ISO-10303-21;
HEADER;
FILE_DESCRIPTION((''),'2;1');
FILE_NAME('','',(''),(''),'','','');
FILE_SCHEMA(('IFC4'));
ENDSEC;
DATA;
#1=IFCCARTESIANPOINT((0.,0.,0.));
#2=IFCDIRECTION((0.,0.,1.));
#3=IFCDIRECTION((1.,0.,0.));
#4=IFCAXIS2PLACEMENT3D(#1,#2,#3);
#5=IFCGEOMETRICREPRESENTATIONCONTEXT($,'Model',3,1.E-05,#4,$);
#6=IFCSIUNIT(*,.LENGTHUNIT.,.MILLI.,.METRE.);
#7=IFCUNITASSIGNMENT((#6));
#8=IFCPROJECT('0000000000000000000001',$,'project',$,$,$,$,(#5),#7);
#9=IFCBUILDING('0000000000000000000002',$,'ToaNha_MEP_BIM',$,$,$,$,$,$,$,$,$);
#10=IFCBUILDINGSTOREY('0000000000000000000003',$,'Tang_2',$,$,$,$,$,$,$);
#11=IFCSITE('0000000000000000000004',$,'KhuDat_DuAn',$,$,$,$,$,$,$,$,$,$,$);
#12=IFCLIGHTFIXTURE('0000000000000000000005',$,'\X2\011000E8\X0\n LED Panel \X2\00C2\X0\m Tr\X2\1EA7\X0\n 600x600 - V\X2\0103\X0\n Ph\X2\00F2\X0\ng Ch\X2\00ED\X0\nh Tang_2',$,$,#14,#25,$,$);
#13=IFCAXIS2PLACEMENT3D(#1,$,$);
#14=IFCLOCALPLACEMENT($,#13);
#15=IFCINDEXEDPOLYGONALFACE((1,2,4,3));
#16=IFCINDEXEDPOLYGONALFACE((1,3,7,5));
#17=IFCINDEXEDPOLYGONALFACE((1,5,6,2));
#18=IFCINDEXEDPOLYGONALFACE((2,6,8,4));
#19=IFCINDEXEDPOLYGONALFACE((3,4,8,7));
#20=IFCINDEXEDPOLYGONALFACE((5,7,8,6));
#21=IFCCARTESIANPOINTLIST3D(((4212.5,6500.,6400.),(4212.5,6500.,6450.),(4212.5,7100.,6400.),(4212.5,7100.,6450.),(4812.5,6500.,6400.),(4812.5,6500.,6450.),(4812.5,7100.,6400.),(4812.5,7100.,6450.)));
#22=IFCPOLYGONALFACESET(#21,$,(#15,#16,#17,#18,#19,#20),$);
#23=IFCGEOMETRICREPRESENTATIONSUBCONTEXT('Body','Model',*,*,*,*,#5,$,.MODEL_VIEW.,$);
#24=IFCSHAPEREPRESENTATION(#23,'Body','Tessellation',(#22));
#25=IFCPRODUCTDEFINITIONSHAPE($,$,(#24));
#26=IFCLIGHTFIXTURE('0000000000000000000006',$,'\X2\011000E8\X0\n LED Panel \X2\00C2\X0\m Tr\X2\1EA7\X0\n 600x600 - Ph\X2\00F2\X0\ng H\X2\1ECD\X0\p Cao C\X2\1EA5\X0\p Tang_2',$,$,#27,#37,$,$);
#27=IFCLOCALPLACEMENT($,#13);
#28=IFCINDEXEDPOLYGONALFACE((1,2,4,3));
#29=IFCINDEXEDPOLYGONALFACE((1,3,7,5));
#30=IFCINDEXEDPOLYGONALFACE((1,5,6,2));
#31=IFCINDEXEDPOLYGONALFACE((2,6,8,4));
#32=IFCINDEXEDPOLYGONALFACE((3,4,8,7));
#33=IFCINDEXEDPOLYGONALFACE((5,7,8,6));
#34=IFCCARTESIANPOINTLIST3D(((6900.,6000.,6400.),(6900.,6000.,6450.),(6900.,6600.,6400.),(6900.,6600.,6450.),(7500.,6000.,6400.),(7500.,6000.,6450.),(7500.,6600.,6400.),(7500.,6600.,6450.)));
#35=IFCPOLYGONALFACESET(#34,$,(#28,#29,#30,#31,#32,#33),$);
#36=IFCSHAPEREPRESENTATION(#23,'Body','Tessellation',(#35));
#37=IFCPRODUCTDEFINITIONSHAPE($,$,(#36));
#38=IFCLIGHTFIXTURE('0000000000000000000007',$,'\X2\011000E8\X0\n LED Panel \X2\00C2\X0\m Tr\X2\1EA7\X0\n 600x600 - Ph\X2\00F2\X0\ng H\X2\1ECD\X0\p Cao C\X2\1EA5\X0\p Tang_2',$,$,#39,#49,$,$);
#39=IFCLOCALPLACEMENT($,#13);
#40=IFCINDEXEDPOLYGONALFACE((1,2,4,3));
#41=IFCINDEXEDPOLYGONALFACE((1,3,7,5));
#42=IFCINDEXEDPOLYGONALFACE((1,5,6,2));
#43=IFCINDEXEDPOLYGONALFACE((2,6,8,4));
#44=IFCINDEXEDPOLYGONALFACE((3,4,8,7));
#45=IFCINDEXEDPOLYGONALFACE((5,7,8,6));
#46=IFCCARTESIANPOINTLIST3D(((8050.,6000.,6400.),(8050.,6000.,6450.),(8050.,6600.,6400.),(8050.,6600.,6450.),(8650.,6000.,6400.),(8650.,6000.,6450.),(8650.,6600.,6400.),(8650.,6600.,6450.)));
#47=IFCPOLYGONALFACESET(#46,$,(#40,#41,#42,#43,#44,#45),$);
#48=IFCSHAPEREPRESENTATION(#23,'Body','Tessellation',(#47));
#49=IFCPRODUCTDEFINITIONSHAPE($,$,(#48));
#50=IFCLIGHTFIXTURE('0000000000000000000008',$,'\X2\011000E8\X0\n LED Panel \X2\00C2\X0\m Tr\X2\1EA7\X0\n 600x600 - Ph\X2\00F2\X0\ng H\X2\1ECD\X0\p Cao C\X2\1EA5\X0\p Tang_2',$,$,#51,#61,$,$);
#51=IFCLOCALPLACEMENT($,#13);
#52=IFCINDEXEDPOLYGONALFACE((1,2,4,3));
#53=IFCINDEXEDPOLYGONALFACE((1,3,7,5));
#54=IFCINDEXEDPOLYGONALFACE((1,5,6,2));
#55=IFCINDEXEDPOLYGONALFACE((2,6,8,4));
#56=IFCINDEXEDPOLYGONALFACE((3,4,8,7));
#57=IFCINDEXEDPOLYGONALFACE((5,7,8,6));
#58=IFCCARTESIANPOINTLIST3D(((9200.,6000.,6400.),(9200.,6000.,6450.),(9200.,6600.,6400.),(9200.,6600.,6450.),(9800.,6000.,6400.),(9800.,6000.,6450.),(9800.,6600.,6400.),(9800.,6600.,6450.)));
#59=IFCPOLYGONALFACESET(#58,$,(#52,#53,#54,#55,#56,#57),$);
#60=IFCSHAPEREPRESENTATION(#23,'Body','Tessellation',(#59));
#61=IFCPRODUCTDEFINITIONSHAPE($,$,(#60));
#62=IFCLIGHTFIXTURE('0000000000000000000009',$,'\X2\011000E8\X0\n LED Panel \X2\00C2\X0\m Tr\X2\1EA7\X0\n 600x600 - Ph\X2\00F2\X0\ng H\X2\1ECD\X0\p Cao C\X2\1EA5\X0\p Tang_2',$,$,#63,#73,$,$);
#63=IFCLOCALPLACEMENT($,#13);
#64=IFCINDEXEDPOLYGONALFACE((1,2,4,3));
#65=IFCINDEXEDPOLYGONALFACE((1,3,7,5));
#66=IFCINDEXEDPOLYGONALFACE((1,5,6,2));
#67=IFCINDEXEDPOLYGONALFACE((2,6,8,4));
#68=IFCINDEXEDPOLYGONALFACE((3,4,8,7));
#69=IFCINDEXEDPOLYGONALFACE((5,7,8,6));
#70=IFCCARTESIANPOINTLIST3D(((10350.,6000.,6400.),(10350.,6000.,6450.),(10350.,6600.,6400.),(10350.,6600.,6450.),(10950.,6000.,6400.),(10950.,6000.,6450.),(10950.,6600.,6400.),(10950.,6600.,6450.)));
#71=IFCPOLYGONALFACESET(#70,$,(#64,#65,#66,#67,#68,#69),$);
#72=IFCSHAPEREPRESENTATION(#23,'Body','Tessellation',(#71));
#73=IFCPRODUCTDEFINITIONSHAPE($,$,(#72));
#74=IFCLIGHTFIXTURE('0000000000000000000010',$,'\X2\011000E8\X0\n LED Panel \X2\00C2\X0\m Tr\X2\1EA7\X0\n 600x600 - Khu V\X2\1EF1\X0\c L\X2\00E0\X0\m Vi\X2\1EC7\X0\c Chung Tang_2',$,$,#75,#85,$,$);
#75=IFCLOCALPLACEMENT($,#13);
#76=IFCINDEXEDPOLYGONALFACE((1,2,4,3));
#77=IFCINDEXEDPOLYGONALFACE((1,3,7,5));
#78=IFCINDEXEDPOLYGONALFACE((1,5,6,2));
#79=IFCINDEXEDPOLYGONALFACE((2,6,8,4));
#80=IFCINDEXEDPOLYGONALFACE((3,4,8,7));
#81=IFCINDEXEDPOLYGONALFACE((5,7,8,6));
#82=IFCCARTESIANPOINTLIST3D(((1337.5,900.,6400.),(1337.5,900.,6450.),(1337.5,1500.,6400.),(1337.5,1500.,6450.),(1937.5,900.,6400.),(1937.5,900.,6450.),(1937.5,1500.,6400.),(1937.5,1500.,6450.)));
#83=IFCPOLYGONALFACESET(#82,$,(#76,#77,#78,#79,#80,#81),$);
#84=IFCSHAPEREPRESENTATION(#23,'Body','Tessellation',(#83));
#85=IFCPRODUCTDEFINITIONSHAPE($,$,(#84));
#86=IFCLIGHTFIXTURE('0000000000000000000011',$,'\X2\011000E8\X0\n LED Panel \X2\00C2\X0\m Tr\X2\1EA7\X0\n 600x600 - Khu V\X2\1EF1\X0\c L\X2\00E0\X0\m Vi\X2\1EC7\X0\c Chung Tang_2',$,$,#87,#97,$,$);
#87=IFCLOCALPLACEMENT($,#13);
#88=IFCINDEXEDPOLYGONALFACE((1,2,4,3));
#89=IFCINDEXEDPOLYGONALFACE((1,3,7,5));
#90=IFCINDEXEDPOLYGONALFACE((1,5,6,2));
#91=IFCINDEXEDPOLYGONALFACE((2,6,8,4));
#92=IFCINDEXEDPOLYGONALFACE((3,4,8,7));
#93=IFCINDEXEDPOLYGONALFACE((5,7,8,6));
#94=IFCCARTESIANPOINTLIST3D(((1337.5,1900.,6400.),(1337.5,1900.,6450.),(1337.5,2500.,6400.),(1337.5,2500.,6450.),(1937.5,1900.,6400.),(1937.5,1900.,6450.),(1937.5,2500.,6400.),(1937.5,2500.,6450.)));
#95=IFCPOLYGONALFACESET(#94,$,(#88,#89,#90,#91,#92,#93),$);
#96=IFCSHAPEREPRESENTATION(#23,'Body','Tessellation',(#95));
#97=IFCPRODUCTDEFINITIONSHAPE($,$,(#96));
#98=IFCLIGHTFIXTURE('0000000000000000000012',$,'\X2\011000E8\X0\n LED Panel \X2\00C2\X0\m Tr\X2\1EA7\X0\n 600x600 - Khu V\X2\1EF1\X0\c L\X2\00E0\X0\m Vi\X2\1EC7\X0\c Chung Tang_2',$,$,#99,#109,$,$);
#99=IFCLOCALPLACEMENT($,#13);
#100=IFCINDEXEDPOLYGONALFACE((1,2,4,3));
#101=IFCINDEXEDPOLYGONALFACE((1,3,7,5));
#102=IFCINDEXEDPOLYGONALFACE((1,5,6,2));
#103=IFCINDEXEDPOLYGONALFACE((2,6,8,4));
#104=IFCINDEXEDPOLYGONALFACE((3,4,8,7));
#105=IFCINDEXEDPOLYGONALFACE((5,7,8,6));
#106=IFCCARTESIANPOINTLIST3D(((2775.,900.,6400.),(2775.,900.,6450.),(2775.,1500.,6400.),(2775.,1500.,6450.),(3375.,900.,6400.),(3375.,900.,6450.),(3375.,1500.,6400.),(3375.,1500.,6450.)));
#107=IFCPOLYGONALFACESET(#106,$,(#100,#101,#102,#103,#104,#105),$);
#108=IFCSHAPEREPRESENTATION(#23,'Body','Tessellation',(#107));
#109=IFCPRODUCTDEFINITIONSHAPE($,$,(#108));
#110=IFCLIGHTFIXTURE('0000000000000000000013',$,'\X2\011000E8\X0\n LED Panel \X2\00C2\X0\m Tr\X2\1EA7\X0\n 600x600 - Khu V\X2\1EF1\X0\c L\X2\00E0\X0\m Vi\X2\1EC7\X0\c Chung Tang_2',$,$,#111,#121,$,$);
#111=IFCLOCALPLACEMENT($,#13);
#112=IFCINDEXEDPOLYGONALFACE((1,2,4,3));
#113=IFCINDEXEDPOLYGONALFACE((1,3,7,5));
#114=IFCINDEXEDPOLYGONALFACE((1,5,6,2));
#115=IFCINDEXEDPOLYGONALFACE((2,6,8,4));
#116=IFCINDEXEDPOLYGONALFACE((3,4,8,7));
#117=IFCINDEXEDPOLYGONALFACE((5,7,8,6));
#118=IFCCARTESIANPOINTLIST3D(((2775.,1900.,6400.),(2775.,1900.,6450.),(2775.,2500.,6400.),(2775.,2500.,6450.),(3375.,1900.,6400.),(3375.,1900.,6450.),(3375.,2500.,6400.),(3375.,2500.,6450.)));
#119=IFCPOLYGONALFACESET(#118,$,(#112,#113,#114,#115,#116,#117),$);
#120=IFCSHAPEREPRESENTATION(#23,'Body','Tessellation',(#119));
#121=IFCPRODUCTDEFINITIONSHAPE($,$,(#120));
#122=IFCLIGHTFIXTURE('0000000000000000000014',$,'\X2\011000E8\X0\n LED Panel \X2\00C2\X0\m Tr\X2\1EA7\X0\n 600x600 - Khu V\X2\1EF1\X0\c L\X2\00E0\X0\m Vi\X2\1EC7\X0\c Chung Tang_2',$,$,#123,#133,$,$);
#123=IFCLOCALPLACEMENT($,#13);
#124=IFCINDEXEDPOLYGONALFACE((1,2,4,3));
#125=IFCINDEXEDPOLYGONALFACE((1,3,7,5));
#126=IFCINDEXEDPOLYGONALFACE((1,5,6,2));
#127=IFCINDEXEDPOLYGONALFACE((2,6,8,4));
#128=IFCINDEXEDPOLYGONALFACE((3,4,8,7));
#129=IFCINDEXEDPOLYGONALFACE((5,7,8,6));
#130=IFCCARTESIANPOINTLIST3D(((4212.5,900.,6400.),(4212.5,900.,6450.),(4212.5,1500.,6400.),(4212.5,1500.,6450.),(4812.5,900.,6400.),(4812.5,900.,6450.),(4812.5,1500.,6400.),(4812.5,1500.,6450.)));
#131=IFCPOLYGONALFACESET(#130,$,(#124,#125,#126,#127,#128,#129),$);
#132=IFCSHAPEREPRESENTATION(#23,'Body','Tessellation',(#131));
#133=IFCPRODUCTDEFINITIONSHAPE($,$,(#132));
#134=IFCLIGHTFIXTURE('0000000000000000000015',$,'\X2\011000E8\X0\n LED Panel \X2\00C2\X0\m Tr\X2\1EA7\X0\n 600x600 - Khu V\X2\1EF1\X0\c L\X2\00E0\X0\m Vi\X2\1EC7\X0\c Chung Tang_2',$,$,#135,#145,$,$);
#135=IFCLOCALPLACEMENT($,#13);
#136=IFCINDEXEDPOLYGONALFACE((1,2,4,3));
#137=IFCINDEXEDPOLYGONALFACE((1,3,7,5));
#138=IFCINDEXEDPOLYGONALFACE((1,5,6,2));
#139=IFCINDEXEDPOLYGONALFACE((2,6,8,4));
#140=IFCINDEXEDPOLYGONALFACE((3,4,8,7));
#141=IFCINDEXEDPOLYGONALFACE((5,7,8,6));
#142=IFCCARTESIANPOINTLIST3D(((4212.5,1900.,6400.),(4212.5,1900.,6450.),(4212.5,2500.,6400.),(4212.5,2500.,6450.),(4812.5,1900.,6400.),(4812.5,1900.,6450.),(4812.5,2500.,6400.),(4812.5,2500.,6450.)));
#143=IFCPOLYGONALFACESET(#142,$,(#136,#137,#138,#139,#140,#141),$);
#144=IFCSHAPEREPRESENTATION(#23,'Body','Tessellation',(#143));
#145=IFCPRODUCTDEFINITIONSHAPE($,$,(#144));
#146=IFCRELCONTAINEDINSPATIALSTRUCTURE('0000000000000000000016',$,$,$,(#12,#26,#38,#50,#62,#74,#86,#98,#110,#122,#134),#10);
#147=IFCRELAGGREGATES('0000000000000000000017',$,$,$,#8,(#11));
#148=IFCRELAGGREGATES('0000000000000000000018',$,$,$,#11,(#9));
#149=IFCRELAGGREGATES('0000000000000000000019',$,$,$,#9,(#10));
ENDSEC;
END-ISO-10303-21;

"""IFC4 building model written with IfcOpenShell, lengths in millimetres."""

from ifc_helpers import new_model, si_unit, frame, origin_with_axes, context, subcontext, project, spatial, polyline, outline, extrude, element, save


model = new_model("IFC4")

# Units and contexts
model_context = context("Model", 3, precision=1e-05, world=origin_with_axes())
body_context = subcontext(model_context, "Body", "Model", "MODEL_VIEW")
ifc_project = project(units=[si_unit("LENGTHUNIT", "METRE", prefix="MILLI")], contexts=[model_context])

# Site, building, storey
site = spatial("IfcSite", under=ifc_project, Name="KhuDat_DuAn")
building = spatial("IfcBuilding", under=site, Name="ToaNha_MEP_BIM")
storey = spatial("IfcBuildingStorey", under=building, Name="Tang_2")

# Light fixtures
element("IfcLightFixture", 1, inside=storey, Name="Đèn LED Panel Âm Trần 600x600 - Văn Phòng Chính Tang_2", context=body_context, shape_type="SweptSolid", body=[
    extrude(outline(polyline([(4212.5, 6500.0), (4812.5, 6500.0), (4812.5, 7100.0), (4212.5, 7100.0), (4212.5, 6500.0)])), frame((0.0, 0.0, 6400.0), z_axis=(0.0, 0.0, 1.0), x_axis=(1.0, 0.0, 0.0)), (0.0, 0.0, 1.0), 50.0),
])
element("IfcLightFixture", 2, inside=storey, Name="Đèn LED Panel Âm Trần 600x600 - Phòng Họp Cao Cấp Tang_2", context=body_context, shape_type="SweptSolid", body=[
    extrude(outline(polyline([(6900.0, 6000.0), (7500.0, 6000.0), (7500.0, 6600.0), (6900.0, 6600.0), (6900.0, 6000.0)])), frame((0.0, 0.0, 6400.0), z_axis=(0.0, 0.0, 1.0), x_axis=(1.0, 0.0, 0.0)), (0.0, 0.0, 1.0), 50.0),
])
element("IfcLightFixture", 3, inside=storey, Name="Đèn LED Panel Âm Trần 600x600 - Phòng Họp Cao Cấp Tang_2", context=body_context, shape_type="SweptSolid", body=[
    extrude(outline(polyline([(8050.0, 6000.0), (8650.0, 6000.0), (8650.0, 6600.0), (8050.0, 6600.0), (8050.0, 6000.0)])), frame((0.0, 0.0, 6400.0), z_axis=(0.0, 0.0, 1.0), x_axis=(1.0, 0.0, 0.0)), (0.0, 0.0, 1.0), 50.0),
])
element("IfcLightFixture", 4, inside=storey, Name="Đèn LED Panel Âm Trần 600x600 - Phòng Họp Cao Cấp Tang_2", context=body_context, shape_type="SweptSolid", body=[
    extrude(outline(polyline([(9200.0, 6000.0), (9800.0, 6000.0), (9800.0, 6600.0), (9200.0, 6600.0), (9200.0, 6000.0)])), frame((0.0, 0.0, 6400.0), z_axis=(0.0, 0.0, 1.0), x_axis=(1.0, 0.0, 0.0)), (0.0, 0.0, 1.0), 50.0),
])
element("IfcLightFixture", 5, inside=storey, Name="Đèn LED Panel Âm Trần 600x600 - Phòng Họp Cao Cấp Tang_2", context=body_context, shape_type="SweptSolid", body=[
    extrude(outline(polyline([(10350.0, 6000.0), (10950.0, 6000.0), (10950.0, 6600.0), (10350.0, 6600.0), (10350.0, 6000.0)])), frame((0.0, 0.0, 6400.0), z_axis=(0.0, 0.0, 1.0), x_axis=(1.0, 0.0, 0.0)), (0.0, 0.0, 1.0), 50.0),
])
element("IfcLightFixture", 6, inside=storey, Name="Đèn LED Panel Âm Trần 600x600 - Khu Vực Làm Việc Chung Tang_2", context=body_context, shape_type="SweptSolid", body=[
    extrude(outline(polyline([(1337.5, 900.0), (1937.5, 900.0), (1937.5, 1500.0), (1337.5, 1500.0), (1337.5, 900.0)])), frame((0.0, 0.0, 6400.0), z_axis=(0.0, 0.0, 1.0), x_axis=(1.0, 0.0, 0.0)), (0.0, 0.0, 1.0), 50.0),
])
element("IfcLightFixture", 7, inside=storey, Name="Đèn LED Panel Âm Trần 600x600 - Khu Vực Làm Việc Chung Tang_2", context=body_context, shape_type="SweptSolid", body=[
    extrude(outline(polyline([(1337.5, 1900.0), (1937.5, 1900.0), (1937.5, 2500.0), (1337.5, 2500.0), (1337.5, 1900.0)])), frame((0.0, 0.0, 6400.0), z_axis=(0.0, 0.0, 1.0), x_axis=(1.0, 0.0, 0.0)), (0.0, 0.0, 1.0), 50.0),
])
element("IfcLightFixture", 8, inside=storey, Name="Đèn LED Panel Âm Trần 600x600 - Khu Vực Làm Việc Chung Tang_2", context=body_context, shape_type="SweptSolid", body=[
    extrude(outline(polyline([(2775.0, 900.0), (3375.0, 900.0), (3375.0, 1500.0), (2775.0, 1500.0), (2775.0, 900.0)])), frame((0.0, 0.0, 6400.0), z_axis=(0.0, 0.0, 1.0), x_axis=(1.0, 0.0, 0.0)), (0.0, 0.0, 1.0), 50.0),
])
element("IfcLightFixture", 9, inside=storey, Name="Đèn LED Panel Âm Trần 600x600 - Khu Vực Làm Việc Chung Tang_2", context=body_context, shape_type="SweptSolid", body=[
    extrude(outline(polyline([(2775.0, 1900.0), (3375.0, 1900.0), (3375.0, 2500.0), (2775.0, 2500.0), (2775.0, 1900.0)])), frame((0.0, 0.0, 6400.0), z_axis=(0.0, 0.0, 1.0), x_axis=(1.0, 0.0, 0.0)), (0.0, 0.0, 1.0), 50.0),
])
element("IfcLightFixture", 10, inside=storey, Name="Đèn LED Panel Âm Trần 600x600 - Khu Vực Làm Việc Chung Tang_2", context=body_context, shape_type="SweptSolid", body=[
    extrude(outline(polyline([(4212.5, 900.0), (4812.5, 900.0), (4812.5, 1500.0), (4212.5, 1500.0), (4212.5, 900.0)])), frame((0.0, 0.0, 6400.0), z_axis=(0.0, 0.0, 1.0), x_axis=(1.0, 0.0, 0.0)), (0.0, 0.0, 1.0), 50.0),
])
element("IfcLightFixture", 11, inside=storey, Name="Đèn LED Panel Âm Trần 600x600 - Khu Vực Làm Việc Chung Tang_2", context=body_context, shape_type="SweptSolid", body=[
    extrude(outline(polyline([(4212.5, 1900.0), (4812.5, 1900.0), (4812.5, 2500.0), (4212.5, 2500.0), (4212.5, 1900.0)])), frame((0.0, 0.0, 6400.0), z_axis=(0.0, 0.0, 1.0), x_axis=(1.0, 0.0, 0.0)), (0.0, 0.0, 1.0), 50.0),
])

save(model, "model.ifc")
